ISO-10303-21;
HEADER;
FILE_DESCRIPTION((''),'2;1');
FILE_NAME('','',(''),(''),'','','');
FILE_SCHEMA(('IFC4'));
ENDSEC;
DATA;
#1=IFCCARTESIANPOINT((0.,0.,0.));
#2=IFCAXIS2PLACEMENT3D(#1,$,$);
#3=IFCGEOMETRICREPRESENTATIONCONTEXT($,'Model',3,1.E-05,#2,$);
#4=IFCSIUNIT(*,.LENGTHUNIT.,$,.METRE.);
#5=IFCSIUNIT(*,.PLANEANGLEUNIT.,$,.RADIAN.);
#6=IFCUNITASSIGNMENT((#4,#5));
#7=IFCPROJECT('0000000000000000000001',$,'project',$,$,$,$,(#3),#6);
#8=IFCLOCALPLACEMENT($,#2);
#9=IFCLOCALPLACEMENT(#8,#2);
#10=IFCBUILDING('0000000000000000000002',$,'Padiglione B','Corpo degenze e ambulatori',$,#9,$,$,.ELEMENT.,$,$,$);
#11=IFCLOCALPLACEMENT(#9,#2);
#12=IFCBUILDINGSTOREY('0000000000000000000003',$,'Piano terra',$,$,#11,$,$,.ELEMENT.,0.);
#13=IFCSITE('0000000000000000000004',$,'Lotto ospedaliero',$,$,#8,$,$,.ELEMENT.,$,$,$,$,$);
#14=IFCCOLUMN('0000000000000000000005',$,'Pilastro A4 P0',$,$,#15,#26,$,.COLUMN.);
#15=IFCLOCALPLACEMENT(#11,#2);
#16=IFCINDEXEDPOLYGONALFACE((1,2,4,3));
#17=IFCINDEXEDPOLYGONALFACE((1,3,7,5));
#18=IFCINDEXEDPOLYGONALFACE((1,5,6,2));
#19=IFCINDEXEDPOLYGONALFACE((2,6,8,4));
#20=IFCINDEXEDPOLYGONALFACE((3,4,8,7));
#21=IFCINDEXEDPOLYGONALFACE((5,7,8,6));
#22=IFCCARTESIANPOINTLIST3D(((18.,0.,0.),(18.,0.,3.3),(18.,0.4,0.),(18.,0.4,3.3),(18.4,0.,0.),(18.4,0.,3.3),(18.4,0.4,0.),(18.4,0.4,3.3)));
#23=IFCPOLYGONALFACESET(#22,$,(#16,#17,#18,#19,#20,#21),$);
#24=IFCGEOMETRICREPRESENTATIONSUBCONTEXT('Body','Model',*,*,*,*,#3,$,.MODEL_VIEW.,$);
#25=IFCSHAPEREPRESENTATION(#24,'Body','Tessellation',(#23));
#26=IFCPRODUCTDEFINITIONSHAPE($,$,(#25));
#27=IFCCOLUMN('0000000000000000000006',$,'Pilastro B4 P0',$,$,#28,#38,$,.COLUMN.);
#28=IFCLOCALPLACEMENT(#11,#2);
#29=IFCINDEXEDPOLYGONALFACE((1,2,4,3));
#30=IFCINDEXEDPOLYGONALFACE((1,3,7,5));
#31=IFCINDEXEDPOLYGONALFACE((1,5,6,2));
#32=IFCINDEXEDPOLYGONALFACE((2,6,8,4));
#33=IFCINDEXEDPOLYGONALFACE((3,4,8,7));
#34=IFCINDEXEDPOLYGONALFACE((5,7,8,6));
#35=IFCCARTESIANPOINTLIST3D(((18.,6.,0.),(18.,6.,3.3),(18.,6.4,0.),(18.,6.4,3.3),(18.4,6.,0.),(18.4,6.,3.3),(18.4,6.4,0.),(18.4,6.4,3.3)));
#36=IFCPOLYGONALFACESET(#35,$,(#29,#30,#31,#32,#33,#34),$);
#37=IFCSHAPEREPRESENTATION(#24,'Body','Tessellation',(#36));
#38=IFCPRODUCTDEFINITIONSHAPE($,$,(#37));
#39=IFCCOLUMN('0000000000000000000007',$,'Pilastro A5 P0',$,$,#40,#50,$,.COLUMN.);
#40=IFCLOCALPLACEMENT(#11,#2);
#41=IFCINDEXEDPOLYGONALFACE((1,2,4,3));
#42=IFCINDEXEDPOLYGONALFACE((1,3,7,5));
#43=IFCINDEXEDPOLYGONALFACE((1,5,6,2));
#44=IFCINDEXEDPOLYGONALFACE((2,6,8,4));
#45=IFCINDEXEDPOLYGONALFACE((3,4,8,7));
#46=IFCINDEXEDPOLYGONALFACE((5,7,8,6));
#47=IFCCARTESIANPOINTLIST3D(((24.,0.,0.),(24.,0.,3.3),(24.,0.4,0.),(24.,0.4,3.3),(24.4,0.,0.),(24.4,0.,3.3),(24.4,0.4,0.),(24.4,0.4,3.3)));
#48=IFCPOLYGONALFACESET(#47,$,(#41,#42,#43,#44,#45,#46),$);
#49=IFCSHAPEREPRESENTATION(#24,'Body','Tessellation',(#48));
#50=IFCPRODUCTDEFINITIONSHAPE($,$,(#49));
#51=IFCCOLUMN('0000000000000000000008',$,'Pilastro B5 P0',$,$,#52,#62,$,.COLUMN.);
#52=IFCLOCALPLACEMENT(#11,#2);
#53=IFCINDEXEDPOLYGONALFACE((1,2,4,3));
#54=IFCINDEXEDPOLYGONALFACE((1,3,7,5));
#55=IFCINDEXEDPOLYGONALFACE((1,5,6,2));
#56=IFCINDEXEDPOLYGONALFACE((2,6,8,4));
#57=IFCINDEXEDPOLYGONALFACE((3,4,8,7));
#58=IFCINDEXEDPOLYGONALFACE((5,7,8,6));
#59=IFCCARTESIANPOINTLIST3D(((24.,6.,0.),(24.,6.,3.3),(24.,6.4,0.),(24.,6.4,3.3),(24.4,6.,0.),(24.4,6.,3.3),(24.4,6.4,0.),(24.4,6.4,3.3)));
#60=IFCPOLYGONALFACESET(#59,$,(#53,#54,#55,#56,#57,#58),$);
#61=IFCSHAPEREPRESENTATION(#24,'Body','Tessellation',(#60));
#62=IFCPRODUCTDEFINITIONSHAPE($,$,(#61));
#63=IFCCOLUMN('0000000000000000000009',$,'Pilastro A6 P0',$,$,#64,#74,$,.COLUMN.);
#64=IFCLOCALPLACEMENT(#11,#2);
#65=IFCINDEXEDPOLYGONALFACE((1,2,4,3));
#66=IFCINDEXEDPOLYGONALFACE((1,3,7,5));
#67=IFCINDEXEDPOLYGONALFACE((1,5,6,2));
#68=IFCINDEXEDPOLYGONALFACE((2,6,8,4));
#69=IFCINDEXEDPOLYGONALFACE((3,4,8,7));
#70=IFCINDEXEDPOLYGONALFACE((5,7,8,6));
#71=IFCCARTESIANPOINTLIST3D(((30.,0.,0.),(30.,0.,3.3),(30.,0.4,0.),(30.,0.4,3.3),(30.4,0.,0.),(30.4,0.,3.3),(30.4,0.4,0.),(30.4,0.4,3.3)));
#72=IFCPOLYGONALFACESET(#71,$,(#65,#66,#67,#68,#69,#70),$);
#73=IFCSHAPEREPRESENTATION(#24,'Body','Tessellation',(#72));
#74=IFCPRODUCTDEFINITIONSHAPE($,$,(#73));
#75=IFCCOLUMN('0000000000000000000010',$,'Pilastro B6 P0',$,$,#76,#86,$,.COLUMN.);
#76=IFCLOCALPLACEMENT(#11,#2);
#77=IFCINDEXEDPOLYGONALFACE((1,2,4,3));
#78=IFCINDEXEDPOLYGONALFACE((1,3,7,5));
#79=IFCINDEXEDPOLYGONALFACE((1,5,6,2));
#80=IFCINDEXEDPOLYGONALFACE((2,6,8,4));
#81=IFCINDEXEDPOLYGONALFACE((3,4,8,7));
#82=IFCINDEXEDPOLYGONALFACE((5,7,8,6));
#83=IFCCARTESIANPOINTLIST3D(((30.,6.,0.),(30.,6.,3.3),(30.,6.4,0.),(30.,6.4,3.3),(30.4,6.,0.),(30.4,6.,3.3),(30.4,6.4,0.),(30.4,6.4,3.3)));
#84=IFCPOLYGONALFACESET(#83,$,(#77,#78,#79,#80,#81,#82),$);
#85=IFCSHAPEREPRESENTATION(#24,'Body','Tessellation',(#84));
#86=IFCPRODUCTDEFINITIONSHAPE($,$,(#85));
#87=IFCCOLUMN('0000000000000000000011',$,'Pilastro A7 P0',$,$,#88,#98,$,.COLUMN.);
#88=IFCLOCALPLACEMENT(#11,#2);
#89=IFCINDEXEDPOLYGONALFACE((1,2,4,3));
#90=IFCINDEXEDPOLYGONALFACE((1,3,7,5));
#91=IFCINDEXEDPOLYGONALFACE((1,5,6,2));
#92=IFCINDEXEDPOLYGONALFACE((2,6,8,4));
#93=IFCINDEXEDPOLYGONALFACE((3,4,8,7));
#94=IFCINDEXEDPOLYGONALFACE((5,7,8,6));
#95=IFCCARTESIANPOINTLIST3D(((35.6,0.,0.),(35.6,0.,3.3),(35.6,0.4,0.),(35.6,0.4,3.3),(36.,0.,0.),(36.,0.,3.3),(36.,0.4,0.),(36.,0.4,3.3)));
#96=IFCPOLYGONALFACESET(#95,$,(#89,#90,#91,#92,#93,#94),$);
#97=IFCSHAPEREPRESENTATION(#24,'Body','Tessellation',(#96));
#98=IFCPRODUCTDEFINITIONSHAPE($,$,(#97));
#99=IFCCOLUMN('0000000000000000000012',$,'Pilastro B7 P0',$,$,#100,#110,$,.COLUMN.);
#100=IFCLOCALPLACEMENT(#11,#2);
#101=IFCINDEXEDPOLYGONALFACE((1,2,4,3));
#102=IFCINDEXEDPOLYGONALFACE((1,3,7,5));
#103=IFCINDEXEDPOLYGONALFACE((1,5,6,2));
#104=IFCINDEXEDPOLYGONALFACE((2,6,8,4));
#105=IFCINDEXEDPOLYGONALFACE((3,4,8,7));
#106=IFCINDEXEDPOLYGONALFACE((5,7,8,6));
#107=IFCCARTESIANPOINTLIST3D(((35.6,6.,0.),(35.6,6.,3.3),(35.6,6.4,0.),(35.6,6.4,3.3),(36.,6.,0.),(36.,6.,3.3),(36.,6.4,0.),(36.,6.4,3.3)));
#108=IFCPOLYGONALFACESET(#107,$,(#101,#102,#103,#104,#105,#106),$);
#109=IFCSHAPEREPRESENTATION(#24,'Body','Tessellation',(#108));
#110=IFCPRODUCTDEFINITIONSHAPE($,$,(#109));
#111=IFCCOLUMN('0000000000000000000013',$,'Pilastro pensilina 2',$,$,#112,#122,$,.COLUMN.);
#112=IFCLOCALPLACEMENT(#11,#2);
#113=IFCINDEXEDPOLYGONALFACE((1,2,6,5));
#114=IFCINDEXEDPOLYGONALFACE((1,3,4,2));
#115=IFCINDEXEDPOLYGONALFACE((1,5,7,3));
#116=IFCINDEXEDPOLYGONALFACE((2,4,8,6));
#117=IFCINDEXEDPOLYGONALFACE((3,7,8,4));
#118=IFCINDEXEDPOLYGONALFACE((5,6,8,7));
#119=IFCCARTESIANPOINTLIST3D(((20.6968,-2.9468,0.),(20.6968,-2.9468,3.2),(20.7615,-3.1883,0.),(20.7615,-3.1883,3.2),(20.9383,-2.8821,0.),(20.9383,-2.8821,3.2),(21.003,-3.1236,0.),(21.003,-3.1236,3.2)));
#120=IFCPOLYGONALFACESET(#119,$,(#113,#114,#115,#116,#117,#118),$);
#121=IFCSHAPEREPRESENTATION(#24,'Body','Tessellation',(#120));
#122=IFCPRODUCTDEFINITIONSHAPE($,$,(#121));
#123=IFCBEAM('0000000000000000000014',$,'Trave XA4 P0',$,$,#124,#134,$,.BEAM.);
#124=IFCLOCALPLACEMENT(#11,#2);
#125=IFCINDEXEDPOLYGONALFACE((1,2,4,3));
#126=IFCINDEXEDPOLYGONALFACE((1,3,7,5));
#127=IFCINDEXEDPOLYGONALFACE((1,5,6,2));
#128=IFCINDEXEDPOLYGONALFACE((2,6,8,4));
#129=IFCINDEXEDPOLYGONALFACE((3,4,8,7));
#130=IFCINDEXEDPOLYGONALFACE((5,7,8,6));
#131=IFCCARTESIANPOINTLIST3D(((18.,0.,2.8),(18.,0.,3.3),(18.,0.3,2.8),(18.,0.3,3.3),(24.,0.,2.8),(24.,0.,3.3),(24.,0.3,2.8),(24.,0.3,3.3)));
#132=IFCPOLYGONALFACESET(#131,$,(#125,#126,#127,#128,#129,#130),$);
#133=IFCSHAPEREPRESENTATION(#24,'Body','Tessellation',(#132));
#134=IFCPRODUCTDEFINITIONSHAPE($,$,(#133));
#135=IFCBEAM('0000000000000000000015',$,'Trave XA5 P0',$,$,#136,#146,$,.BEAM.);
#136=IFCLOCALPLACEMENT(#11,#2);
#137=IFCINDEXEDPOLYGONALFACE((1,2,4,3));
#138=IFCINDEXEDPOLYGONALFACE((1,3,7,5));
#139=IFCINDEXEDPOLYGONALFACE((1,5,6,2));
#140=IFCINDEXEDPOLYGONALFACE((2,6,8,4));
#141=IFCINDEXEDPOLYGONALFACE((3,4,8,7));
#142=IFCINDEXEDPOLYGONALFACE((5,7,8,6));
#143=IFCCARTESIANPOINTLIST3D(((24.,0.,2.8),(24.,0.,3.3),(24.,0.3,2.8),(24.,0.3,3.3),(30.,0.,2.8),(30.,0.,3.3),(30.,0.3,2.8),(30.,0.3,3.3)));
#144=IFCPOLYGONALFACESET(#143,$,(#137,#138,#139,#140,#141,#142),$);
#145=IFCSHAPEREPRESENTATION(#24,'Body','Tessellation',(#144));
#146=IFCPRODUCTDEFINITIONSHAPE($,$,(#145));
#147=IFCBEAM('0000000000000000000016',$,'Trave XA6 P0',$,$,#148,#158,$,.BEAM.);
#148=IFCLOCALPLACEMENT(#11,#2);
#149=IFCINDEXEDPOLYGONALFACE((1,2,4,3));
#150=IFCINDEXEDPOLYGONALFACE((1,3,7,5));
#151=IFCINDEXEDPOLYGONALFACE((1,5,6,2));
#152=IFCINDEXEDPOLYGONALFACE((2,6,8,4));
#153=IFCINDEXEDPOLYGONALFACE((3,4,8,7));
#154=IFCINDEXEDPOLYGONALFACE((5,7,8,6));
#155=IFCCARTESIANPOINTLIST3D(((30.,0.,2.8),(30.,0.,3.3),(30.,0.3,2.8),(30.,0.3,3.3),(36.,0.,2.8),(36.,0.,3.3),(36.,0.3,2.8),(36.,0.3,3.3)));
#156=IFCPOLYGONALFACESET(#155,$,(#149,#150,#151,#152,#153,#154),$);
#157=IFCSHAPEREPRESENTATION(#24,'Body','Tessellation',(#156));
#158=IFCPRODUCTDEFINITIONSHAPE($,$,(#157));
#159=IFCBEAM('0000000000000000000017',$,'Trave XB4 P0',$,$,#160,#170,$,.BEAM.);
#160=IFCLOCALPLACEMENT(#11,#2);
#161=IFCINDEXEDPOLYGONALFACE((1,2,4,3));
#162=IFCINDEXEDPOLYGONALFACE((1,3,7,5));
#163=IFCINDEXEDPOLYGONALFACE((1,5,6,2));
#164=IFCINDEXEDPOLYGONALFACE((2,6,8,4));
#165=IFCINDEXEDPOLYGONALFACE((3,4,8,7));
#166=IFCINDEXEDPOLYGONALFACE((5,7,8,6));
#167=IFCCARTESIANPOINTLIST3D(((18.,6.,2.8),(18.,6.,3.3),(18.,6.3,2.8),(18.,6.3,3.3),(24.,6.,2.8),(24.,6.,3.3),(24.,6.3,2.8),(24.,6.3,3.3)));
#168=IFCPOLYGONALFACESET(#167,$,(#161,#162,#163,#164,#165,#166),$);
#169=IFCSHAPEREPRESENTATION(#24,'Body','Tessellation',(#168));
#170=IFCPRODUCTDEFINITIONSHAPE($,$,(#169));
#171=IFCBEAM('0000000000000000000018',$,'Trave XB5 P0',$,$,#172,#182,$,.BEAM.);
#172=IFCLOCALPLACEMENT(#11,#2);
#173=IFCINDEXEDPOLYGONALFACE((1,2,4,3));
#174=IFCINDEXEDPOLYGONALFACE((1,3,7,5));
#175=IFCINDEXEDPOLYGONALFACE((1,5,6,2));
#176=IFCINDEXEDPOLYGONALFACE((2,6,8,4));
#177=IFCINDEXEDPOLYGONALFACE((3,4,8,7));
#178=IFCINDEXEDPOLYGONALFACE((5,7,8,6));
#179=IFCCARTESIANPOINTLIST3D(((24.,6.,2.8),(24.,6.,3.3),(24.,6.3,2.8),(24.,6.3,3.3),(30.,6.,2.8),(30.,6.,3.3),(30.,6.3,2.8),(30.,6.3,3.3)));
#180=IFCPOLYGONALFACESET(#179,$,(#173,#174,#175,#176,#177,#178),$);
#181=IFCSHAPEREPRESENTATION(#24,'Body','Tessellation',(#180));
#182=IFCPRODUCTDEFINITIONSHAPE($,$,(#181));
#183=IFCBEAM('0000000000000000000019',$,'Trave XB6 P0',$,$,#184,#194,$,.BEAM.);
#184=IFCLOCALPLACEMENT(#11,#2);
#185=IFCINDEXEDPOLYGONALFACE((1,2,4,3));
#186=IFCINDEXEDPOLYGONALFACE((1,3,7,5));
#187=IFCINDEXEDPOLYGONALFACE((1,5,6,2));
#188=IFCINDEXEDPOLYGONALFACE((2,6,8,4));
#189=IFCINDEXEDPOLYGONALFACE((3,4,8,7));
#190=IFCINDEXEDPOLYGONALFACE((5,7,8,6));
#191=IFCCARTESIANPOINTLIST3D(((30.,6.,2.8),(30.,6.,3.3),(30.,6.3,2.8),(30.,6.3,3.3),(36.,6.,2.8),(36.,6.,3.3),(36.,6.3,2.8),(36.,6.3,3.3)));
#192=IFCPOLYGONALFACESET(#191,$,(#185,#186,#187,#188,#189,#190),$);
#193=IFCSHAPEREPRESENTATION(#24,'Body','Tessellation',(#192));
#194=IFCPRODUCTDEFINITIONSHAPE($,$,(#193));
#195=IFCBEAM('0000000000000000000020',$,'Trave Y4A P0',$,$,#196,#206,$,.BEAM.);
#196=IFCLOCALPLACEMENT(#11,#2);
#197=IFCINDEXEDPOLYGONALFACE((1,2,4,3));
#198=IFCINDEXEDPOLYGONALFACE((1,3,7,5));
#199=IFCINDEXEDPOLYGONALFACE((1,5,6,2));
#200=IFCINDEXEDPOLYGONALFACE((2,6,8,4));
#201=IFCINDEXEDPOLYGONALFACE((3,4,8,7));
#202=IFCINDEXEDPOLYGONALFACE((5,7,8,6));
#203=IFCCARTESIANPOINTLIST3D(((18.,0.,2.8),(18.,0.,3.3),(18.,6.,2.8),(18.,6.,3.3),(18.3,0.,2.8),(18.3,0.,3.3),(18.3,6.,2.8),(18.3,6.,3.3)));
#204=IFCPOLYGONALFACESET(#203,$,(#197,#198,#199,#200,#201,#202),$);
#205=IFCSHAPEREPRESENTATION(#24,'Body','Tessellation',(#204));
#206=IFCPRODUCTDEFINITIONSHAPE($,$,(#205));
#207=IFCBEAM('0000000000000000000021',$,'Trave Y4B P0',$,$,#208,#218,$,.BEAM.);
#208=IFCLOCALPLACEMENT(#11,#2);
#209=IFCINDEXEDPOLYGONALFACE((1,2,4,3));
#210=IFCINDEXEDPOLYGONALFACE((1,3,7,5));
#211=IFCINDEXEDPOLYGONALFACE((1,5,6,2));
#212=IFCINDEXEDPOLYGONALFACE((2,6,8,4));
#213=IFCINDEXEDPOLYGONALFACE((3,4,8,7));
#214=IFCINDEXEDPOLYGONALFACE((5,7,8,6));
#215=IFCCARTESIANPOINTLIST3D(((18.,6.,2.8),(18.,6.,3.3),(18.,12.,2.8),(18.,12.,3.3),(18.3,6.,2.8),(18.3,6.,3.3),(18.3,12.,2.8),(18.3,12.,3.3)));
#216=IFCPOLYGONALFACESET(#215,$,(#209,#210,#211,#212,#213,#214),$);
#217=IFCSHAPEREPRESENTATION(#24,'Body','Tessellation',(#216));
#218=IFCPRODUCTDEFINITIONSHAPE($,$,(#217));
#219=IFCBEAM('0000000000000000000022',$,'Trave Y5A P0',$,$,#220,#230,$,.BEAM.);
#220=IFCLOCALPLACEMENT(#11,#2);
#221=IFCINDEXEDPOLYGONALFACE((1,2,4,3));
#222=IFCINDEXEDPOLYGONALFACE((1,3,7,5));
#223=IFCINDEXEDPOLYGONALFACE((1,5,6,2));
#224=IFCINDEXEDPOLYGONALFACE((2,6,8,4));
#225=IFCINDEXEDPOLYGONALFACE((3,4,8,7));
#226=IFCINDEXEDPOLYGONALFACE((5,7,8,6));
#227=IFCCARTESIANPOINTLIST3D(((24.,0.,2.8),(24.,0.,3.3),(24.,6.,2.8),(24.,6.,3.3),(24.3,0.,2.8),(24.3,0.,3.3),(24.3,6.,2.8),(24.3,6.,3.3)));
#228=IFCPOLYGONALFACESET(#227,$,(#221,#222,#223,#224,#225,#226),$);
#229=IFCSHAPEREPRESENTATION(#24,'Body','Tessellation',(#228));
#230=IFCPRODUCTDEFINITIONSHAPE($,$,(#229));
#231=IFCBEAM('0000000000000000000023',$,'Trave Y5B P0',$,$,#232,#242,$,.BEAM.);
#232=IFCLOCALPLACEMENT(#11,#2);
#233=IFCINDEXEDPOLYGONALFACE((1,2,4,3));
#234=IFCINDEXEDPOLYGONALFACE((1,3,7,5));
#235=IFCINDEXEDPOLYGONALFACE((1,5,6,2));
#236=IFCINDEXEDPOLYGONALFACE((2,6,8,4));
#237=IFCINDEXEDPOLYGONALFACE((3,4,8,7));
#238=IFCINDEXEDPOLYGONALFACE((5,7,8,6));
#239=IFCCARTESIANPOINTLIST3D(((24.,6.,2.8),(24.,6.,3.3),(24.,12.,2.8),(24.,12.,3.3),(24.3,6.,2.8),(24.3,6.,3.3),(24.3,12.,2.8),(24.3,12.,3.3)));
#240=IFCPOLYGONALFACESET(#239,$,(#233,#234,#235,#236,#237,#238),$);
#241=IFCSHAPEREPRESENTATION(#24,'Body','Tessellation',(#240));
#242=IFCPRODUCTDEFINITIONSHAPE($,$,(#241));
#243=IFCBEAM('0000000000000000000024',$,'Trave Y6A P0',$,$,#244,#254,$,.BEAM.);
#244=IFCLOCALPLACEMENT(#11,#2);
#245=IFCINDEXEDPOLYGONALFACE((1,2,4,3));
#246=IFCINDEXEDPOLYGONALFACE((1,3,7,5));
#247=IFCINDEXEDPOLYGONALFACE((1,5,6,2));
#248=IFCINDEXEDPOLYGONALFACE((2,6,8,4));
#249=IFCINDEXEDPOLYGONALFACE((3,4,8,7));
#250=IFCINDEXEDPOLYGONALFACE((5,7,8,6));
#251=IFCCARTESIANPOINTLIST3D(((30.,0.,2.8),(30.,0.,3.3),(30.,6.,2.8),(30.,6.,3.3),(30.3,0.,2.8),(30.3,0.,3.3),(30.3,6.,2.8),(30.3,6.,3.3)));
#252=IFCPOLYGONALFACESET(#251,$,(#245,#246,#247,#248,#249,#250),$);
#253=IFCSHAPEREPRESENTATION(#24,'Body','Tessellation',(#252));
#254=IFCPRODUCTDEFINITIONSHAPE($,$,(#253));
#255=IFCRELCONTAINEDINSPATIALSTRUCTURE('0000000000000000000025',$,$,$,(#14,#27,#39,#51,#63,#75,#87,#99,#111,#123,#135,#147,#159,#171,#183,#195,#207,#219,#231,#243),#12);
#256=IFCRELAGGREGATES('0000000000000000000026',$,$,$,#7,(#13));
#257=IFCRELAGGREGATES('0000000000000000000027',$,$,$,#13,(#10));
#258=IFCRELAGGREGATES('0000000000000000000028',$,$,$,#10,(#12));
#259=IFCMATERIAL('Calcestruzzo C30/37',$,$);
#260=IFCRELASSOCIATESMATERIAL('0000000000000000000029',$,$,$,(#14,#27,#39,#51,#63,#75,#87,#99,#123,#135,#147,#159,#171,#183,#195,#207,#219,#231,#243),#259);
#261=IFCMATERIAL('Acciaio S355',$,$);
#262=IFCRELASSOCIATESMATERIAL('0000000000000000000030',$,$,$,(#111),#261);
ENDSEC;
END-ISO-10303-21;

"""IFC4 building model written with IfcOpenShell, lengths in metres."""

from ifc_helpers import new_model, si_unit, frame, frame_2d, origin, place, context, subcontext, project, spatial, rectangle, extrude, material, element, save


model = new_model("IFC4")

# Units and contexts
model_context = context("Model", 3, precision=1e-05, world=origin())
body_context = subcontext(model_context, "Body", "Model", "MODEL_VIEW")
ifc_project = project(units=[si_unit("LENGTHUNIT", "METRE"), si_unit("PLANEANGLEUNIT", "RADIAN")], contexts=[model_context])

# Site, building, storey
site_placement = place(None, origin())
site = spatial("IfcSite", under=ifc_project, at=site_placement, Name="Lotto ospedaliero", CompositionType="ELEMENT")
building_placement = place(site_placement, origin())
building = spatial("IfcBuilding", under=site, at=building_placement, Name="Padiglione B", Description="Corpo degenze e ambulatori", CompositionType="ELEMENT")
storey_placement = place(building_placement, origin())
storey = spatial("IfcBuildingStorey", under=building, at=storey_placement, Name="Piano terra", CompositionType="ELEMENT", Elevation=0.0)

# Columns
ifc_material_1 = material(Name="Calcestruzzo C30/37")
for number, where, name in (
    (1, (18.0, 0.0, 0.0), "Pilastro A4 P0"),
    (2, (18.0, 6.0, 0.0), "Pilastro B4 P0"),
    (3, (24.0, 0.0, 0.0), "Pilastro A5 P0"),
    (4, (24.0, 6.0, 0.0), "Pilastro B5 P0"),
    (5, (30.0, 0.0, 0.0), "Pilastro A6 P0"),
    (6, (30.0, 6.0, 0.0), "Pilastro B6 P0"),
    (7, (35.6, 0.0, 0.0), "Pilastro A7 P0"),
    (8, (35.6, 6.0, 0.0), "Pilastro B7 P0"),
):
    element("IfcColumn", number, at=place(storey_placement, frame(where)), inside=storey, material=ifc_material_1, Name=name, PredefinedType="COLUMN", context=body_context, shape_type="SweptSolid", body=[
        extrude(rectangle(XDim=0.4, YDim=0.4, at=frame_2d((0.2, 0.2))), origin(), (0.0, 0.0, 1.0), 3.3),
    ])
ifc_material_2 = material(Name="Acciaio S355")
column_placement = place(storey_placement, frame((20.7615, -3.1883, 0.0), z_axis=(0.0, 0.0, 1.0), x_axis=(0.9659, 0.2588, 0.0)))
element("IfcColumn", 9, at=column_placement, inside=storey, material=ifc_material_2, Name="Pilastro pensilina 2", PredefinedType="COLUMN", context=body_context, shape_type="SweptSolid", body=[
    extrude(rectangle(XDim=0.25, YDim=0.25, at=frame_2d((0.125, 0.125))), origin(), (0.0, 0.0, 1.0), 3.2),
])

# Beams
for number, where, name in (
    (10, (18.0, 0.0, 2.8), "Trave XA4 P0"),
    (11, (24.0, 0.0, 2.8), "Trave XA5 P0"),
    (12, (30.0, 0.0, 2.8), "Trave XA6 P0"),
    (13, (18.0, 6.0, 2.8), "Trave XB4 P0"),
    (14, (24.0, 6.0, 2.8), "Trave XB5 P0"),
    (15, (30.0, 6.0, 2.8), "Trave XB6 P0"),
):
    element("IfcBeam", number, at=place(storey_placement, frame(where)), inside=storey, material=ifc_material_1, Name=name, PredefinedType="BEAM", context=body_context, shape_type="SweptSolid", body=[
        extrude(rectangle(XDim=6.0, YDim=0.3, at=frame_2d((3.0, 0.15))), origin(), (0.0, 0.0, 1.0), 0.5),
    ])
for number, where, name in (
    (16, (18.0, 0.0, 2.8), "Trave Y4A P0"),
    (17, (18.0, 6.0, 2.8), "Trave Y4B P0"),
    (18, (24.0, 0.0, 2.8), "Trave Y5A P0"),
    (19, (24.0, 6.0, 2.8), "Trave Y5B P0"),
    (20, (30.0, 0.0, 2.8), "Trave Y6A P0"),
):
    element("IfcBeam", number, at=place(storey_placement, frame(where)), inside=storey, material=ifc_material_1, Name=name, PredefinedType="BEAM", context=body_context, shape_type="SweptSolid", body=[
        extrude(rectangle(XDim=0.3, YDim=6.0, at=frame_2d((0.15, 3.0))), origin(), (0.0, 0.0, 1.0), 0.5),
    ])

save(model, "model.ifc")
